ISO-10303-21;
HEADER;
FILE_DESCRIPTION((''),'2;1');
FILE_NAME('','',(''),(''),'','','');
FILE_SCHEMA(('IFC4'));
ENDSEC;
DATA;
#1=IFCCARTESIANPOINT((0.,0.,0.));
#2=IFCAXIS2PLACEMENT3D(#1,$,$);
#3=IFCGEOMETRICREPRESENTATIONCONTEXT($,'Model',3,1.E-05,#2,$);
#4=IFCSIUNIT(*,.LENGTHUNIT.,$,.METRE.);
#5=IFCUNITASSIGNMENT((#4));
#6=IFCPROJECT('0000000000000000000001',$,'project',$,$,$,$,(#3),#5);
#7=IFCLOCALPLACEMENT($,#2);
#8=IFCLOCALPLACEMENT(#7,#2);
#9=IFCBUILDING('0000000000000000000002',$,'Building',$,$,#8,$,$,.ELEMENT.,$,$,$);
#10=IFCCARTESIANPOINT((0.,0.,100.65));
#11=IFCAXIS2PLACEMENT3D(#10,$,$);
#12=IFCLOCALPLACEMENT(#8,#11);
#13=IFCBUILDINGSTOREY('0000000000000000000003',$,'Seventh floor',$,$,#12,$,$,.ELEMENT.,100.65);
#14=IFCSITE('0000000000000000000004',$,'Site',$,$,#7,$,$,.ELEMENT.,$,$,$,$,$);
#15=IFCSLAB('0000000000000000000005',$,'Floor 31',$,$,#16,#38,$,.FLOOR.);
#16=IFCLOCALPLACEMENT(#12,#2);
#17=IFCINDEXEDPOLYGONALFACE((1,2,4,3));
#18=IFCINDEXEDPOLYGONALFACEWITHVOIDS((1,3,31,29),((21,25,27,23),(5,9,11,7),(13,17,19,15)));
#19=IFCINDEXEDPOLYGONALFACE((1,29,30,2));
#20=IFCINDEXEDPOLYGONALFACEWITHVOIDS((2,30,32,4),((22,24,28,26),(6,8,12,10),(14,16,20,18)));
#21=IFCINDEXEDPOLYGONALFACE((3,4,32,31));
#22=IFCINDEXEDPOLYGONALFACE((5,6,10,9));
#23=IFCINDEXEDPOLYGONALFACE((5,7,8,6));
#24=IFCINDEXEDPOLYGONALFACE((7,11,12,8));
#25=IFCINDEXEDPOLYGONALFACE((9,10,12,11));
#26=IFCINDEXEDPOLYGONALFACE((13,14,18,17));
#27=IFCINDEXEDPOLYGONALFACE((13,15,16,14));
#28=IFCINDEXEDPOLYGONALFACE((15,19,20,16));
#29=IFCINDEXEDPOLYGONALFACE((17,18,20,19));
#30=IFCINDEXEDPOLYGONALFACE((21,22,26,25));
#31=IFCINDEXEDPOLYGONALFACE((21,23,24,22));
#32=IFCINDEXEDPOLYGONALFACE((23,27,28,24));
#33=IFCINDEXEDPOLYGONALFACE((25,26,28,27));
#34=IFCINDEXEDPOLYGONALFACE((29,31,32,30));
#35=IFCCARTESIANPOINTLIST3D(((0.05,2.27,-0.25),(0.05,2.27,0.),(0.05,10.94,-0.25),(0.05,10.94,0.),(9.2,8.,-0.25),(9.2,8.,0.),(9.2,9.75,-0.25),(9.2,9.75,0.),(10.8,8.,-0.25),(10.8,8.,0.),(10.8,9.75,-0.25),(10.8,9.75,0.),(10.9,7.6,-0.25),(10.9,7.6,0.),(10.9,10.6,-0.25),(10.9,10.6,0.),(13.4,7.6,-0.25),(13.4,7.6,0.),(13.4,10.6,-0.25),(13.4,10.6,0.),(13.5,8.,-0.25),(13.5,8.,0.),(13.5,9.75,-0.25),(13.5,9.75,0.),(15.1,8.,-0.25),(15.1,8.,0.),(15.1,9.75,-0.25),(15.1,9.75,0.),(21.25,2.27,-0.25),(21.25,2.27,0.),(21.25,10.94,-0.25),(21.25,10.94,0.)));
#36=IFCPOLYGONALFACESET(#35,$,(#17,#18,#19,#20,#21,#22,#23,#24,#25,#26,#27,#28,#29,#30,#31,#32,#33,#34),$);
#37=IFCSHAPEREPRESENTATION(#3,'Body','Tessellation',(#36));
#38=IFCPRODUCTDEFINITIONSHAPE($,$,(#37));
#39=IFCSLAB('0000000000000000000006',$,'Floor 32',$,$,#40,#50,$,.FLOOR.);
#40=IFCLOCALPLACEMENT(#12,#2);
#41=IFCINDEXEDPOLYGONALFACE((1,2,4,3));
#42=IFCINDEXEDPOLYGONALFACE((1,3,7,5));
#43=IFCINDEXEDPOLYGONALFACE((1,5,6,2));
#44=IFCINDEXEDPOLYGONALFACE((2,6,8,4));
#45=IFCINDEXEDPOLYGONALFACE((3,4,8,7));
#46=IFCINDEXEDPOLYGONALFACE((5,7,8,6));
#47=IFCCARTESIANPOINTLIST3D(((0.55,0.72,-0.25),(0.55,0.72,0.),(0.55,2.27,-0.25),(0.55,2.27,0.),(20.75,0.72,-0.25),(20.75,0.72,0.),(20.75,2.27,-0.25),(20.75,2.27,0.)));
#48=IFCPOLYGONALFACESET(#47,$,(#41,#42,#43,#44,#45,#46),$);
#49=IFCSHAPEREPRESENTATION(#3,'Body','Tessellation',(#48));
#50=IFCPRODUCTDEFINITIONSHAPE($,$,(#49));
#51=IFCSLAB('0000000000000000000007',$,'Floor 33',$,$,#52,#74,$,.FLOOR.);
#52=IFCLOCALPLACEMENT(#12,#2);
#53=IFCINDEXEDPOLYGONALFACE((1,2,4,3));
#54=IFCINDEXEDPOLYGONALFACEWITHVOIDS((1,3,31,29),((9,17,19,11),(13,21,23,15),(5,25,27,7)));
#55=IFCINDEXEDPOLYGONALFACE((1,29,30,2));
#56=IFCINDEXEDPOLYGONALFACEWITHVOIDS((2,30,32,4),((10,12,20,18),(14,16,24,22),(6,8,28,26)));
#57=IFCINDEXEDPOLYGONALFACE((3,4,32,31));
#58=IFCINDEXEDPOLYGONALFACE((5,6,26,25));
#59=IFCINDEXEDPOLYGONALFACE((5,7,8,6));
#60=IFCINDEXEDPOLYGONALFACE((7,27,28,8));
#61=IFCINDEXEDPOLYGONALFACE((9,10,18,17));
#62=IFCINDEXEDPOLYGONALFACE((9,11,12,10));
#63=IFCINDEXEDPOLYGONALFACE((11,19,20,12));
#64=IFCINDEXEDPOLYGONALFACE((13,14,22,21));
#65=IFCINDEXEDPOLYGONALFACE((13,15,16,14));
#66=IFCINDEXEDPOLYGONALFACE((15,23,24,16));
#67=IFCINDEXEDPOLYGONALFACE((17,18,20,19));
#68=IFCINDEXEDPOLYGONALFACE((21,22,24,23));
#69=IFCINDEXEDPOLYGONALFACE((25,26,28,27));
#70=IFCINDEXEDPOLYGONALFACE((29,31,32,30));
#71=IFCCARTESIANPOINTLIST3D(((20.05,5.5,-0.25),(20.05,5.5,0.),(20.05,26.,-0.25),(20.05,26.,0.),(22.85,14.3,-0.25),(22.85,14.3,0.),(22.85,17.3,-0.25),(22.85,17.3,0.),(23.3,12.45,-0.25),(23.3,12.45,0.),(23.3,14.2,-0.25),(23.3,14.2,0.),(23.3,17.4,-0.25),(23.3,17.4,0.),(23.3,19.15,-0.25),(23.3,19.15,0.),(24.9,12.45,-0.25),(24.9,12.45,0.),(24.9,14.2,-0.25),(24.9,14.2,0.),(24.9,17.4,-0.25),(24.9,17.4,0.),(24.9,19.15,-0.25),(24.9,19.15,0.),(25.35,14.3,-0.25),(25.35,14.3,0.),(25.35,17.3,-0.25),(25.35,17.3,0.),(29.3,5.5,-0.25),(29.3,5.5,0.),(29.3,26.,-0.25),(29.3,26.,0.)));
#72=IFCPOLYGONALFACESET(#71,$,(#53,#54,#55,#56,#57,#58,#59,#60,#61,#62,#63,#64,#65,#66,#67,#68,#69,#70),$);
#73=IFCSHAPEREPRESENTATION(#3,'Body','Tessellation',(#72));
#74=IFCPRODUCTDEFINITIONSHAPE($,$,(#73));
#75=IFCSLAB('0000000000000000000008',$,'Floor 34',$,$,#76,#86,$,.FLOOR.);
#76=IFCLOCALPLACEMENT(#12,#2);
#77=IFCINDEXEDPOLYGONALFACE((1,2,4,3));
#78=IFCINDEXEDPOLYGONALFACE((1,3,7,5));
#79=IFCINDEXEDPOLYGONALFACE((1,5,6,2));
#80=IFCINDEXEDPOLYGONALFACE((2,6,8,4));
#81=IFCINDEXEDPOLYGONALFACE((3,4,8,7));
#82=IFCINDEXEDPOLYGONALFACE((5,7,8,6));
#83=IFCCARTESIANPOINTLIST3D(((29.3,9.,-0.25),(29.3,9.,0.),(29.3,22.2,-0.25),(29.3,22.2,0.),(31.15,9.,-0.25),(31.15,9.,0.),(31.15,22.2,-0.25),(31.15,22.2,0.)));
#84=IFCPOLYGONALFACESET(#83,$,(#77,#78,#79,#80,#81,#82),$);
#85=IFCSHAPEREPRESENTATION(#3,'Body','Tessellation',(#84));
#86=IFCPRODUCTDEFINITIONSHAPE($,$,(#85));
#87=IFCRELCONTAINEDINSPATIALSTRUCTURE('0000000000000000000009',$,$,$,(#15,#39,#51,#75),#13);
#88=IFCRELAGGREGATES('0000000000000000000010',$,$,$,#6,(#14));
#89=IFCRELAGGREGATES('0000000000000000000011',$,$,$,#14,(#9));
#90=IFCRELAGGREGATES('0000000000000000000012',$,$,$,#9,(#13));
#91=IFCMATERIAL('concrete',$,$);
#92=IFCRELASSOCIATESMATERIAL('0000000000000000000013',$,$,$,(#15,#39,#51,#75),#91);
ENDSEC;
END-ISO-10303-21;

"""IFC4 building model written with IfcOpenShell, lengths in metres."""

from ifc_helpers import new_model, si_unit, frame, origin, place, context, project, spatial, polyline, outline, extrude, material, element, save


model = new_model("IFC4")

# Units and contexts
model_context = context("Model", 3, precision=1e-05, world=origin())
ifc_project = project(units=[si_unit("LENGTHUNIT", "METRE")], contexts=[model_context])

# Site, building, storey
site_placement = place(None, origin())
site = spatial("IfcSite", under=ifc_project, at=site_placement, Name="Site", CompositionType="ELEMENT")
building_placement = place(site_placement, origin())
building = spatial("IfcBuilding", under=site, at=building_placement, Name="Building", CompositionType="ELEMENT")
storey_placement = place(building_placement, frame((0.0, 0.0, 100.65)))
storey = spatial("IfcBuildingStorey", under=building, at=storey_placement, Name="Seventh floor", CompositionType="ELEMENT", Elevation=100.65)

# Slabs
ifc_material = material(Name="concrete")
slab_1_placement = place(storey_placement, frame((0.0, 0.0, -0.25), z_axis=(0.0, 0.0, 1.0), x_axis=(1.0, 0.0, 0.0)))
element("IfcSlab", 1, at=slab_1_placement, inside=storey, material=ifc_material, Name="Floor 31", PredefinedType="FLOOR", context=model_context, shape_type="SweptSolid", body=[
    extrude(outline(polyline([(0.05, 2.27), (21.25, 2.27), (21.25, 10.94), (0.05, 10.94), (0.05, 2.27)]), holes=[polyline([(10.9, 7.6), (13.4, 7.6), (13.4, 10.6), (10.9, 10.6), (10.9, 7.6)]), polyline([(9.2, 8.0), (10.8, 8.0), (10.8, 9.75), (9.2, 9.75), (9.2, 8.0)]), polyline([(13.5, 8.0), (15.1, 8.0), (15.1, 9.75), (13.5, 9.75), (13.5, 8.0)])]), origin(), (0.0, 0.0, 1.0), 0.25),
])
slab_2_placement = place(storey_placement, frame((0.0, 0.0, -0.25), z_axis=(0.0, 0.0, 1.0), x_axis=(1.0, 0.0, 0.0)))
element("IfcSlab", 2, at=slab_2_placement, inside=storey, material=ifc_material, Name="Floor 32", PredefinedType="FLOOR", context=model_context, shape_type="SweptSolid", body=[
    extrude(outline(polyline([(0.55, 0.72), (20.75, 0.72), (20.75, 2.27), (0.55, 2.27), (0.55, 0.72)])), origin(), (0.0, 0.0, 1.0), 0.25),
])
slab_3_placement = place(storey_placement, frame((0.0, 0.0, -0.25), z_axis=(0.0, 0.0, 1.0), x_axis=(1.0, 0.0, 0.0)))
element("IfcSlab", 3, at=slab_3_placement, inside=storey, material=ifc_material, Name="Floor 33", PredefinedType="FLOOR", context=model_context, shape_type="SweptSolid", body=[
    extrude(outline(polyline([(20.05, 5.5), (29.3, 5.5), (29.3, 26.0), (20.05, 26.0), (20.05, 5.5)]), holes=[polyline([(22.85, 14.3), (25.35, 14.3), (25.35, 17.3), (22.85, 17.3), (22.85, 14.3)]), polyline([(23.3, 17.4), (24.9, 17.4), (24.9, 19.15), (23.3, 19.15), (23.3, 17.4)]), polyline([(23.3, 12.45), (24.9, 12.45), (24.9, 14.2), (23.3, 14.2), (23.3, 12.45)])]), origin(), (0.0, 0.0, 1.0), 0.25),
])
slab_4_placement = place(storey_placement, frame((0.0, 0.0, -0.25), z_axis=(0.0, 0.0, 1.0), x_axis=(1.0, 0.0, 0.0)))
element("IfcSlab", 4, at=slab_4_placement, inside=storey, material=ifc_material, Name="Floor 34", PredefinedType="FLOOR", context=model_context, shape_type="SweptSolid", body=[
    extrude(outline(polyline([(29.3, 9.0), (31.15, 9.0), (31.15, 22.2), (29.3, 22.2), (29.3, 9.0)])), origin(), (0.0, 0.0, 1.0), 0.25),
])

save(model, "model.ifc")
